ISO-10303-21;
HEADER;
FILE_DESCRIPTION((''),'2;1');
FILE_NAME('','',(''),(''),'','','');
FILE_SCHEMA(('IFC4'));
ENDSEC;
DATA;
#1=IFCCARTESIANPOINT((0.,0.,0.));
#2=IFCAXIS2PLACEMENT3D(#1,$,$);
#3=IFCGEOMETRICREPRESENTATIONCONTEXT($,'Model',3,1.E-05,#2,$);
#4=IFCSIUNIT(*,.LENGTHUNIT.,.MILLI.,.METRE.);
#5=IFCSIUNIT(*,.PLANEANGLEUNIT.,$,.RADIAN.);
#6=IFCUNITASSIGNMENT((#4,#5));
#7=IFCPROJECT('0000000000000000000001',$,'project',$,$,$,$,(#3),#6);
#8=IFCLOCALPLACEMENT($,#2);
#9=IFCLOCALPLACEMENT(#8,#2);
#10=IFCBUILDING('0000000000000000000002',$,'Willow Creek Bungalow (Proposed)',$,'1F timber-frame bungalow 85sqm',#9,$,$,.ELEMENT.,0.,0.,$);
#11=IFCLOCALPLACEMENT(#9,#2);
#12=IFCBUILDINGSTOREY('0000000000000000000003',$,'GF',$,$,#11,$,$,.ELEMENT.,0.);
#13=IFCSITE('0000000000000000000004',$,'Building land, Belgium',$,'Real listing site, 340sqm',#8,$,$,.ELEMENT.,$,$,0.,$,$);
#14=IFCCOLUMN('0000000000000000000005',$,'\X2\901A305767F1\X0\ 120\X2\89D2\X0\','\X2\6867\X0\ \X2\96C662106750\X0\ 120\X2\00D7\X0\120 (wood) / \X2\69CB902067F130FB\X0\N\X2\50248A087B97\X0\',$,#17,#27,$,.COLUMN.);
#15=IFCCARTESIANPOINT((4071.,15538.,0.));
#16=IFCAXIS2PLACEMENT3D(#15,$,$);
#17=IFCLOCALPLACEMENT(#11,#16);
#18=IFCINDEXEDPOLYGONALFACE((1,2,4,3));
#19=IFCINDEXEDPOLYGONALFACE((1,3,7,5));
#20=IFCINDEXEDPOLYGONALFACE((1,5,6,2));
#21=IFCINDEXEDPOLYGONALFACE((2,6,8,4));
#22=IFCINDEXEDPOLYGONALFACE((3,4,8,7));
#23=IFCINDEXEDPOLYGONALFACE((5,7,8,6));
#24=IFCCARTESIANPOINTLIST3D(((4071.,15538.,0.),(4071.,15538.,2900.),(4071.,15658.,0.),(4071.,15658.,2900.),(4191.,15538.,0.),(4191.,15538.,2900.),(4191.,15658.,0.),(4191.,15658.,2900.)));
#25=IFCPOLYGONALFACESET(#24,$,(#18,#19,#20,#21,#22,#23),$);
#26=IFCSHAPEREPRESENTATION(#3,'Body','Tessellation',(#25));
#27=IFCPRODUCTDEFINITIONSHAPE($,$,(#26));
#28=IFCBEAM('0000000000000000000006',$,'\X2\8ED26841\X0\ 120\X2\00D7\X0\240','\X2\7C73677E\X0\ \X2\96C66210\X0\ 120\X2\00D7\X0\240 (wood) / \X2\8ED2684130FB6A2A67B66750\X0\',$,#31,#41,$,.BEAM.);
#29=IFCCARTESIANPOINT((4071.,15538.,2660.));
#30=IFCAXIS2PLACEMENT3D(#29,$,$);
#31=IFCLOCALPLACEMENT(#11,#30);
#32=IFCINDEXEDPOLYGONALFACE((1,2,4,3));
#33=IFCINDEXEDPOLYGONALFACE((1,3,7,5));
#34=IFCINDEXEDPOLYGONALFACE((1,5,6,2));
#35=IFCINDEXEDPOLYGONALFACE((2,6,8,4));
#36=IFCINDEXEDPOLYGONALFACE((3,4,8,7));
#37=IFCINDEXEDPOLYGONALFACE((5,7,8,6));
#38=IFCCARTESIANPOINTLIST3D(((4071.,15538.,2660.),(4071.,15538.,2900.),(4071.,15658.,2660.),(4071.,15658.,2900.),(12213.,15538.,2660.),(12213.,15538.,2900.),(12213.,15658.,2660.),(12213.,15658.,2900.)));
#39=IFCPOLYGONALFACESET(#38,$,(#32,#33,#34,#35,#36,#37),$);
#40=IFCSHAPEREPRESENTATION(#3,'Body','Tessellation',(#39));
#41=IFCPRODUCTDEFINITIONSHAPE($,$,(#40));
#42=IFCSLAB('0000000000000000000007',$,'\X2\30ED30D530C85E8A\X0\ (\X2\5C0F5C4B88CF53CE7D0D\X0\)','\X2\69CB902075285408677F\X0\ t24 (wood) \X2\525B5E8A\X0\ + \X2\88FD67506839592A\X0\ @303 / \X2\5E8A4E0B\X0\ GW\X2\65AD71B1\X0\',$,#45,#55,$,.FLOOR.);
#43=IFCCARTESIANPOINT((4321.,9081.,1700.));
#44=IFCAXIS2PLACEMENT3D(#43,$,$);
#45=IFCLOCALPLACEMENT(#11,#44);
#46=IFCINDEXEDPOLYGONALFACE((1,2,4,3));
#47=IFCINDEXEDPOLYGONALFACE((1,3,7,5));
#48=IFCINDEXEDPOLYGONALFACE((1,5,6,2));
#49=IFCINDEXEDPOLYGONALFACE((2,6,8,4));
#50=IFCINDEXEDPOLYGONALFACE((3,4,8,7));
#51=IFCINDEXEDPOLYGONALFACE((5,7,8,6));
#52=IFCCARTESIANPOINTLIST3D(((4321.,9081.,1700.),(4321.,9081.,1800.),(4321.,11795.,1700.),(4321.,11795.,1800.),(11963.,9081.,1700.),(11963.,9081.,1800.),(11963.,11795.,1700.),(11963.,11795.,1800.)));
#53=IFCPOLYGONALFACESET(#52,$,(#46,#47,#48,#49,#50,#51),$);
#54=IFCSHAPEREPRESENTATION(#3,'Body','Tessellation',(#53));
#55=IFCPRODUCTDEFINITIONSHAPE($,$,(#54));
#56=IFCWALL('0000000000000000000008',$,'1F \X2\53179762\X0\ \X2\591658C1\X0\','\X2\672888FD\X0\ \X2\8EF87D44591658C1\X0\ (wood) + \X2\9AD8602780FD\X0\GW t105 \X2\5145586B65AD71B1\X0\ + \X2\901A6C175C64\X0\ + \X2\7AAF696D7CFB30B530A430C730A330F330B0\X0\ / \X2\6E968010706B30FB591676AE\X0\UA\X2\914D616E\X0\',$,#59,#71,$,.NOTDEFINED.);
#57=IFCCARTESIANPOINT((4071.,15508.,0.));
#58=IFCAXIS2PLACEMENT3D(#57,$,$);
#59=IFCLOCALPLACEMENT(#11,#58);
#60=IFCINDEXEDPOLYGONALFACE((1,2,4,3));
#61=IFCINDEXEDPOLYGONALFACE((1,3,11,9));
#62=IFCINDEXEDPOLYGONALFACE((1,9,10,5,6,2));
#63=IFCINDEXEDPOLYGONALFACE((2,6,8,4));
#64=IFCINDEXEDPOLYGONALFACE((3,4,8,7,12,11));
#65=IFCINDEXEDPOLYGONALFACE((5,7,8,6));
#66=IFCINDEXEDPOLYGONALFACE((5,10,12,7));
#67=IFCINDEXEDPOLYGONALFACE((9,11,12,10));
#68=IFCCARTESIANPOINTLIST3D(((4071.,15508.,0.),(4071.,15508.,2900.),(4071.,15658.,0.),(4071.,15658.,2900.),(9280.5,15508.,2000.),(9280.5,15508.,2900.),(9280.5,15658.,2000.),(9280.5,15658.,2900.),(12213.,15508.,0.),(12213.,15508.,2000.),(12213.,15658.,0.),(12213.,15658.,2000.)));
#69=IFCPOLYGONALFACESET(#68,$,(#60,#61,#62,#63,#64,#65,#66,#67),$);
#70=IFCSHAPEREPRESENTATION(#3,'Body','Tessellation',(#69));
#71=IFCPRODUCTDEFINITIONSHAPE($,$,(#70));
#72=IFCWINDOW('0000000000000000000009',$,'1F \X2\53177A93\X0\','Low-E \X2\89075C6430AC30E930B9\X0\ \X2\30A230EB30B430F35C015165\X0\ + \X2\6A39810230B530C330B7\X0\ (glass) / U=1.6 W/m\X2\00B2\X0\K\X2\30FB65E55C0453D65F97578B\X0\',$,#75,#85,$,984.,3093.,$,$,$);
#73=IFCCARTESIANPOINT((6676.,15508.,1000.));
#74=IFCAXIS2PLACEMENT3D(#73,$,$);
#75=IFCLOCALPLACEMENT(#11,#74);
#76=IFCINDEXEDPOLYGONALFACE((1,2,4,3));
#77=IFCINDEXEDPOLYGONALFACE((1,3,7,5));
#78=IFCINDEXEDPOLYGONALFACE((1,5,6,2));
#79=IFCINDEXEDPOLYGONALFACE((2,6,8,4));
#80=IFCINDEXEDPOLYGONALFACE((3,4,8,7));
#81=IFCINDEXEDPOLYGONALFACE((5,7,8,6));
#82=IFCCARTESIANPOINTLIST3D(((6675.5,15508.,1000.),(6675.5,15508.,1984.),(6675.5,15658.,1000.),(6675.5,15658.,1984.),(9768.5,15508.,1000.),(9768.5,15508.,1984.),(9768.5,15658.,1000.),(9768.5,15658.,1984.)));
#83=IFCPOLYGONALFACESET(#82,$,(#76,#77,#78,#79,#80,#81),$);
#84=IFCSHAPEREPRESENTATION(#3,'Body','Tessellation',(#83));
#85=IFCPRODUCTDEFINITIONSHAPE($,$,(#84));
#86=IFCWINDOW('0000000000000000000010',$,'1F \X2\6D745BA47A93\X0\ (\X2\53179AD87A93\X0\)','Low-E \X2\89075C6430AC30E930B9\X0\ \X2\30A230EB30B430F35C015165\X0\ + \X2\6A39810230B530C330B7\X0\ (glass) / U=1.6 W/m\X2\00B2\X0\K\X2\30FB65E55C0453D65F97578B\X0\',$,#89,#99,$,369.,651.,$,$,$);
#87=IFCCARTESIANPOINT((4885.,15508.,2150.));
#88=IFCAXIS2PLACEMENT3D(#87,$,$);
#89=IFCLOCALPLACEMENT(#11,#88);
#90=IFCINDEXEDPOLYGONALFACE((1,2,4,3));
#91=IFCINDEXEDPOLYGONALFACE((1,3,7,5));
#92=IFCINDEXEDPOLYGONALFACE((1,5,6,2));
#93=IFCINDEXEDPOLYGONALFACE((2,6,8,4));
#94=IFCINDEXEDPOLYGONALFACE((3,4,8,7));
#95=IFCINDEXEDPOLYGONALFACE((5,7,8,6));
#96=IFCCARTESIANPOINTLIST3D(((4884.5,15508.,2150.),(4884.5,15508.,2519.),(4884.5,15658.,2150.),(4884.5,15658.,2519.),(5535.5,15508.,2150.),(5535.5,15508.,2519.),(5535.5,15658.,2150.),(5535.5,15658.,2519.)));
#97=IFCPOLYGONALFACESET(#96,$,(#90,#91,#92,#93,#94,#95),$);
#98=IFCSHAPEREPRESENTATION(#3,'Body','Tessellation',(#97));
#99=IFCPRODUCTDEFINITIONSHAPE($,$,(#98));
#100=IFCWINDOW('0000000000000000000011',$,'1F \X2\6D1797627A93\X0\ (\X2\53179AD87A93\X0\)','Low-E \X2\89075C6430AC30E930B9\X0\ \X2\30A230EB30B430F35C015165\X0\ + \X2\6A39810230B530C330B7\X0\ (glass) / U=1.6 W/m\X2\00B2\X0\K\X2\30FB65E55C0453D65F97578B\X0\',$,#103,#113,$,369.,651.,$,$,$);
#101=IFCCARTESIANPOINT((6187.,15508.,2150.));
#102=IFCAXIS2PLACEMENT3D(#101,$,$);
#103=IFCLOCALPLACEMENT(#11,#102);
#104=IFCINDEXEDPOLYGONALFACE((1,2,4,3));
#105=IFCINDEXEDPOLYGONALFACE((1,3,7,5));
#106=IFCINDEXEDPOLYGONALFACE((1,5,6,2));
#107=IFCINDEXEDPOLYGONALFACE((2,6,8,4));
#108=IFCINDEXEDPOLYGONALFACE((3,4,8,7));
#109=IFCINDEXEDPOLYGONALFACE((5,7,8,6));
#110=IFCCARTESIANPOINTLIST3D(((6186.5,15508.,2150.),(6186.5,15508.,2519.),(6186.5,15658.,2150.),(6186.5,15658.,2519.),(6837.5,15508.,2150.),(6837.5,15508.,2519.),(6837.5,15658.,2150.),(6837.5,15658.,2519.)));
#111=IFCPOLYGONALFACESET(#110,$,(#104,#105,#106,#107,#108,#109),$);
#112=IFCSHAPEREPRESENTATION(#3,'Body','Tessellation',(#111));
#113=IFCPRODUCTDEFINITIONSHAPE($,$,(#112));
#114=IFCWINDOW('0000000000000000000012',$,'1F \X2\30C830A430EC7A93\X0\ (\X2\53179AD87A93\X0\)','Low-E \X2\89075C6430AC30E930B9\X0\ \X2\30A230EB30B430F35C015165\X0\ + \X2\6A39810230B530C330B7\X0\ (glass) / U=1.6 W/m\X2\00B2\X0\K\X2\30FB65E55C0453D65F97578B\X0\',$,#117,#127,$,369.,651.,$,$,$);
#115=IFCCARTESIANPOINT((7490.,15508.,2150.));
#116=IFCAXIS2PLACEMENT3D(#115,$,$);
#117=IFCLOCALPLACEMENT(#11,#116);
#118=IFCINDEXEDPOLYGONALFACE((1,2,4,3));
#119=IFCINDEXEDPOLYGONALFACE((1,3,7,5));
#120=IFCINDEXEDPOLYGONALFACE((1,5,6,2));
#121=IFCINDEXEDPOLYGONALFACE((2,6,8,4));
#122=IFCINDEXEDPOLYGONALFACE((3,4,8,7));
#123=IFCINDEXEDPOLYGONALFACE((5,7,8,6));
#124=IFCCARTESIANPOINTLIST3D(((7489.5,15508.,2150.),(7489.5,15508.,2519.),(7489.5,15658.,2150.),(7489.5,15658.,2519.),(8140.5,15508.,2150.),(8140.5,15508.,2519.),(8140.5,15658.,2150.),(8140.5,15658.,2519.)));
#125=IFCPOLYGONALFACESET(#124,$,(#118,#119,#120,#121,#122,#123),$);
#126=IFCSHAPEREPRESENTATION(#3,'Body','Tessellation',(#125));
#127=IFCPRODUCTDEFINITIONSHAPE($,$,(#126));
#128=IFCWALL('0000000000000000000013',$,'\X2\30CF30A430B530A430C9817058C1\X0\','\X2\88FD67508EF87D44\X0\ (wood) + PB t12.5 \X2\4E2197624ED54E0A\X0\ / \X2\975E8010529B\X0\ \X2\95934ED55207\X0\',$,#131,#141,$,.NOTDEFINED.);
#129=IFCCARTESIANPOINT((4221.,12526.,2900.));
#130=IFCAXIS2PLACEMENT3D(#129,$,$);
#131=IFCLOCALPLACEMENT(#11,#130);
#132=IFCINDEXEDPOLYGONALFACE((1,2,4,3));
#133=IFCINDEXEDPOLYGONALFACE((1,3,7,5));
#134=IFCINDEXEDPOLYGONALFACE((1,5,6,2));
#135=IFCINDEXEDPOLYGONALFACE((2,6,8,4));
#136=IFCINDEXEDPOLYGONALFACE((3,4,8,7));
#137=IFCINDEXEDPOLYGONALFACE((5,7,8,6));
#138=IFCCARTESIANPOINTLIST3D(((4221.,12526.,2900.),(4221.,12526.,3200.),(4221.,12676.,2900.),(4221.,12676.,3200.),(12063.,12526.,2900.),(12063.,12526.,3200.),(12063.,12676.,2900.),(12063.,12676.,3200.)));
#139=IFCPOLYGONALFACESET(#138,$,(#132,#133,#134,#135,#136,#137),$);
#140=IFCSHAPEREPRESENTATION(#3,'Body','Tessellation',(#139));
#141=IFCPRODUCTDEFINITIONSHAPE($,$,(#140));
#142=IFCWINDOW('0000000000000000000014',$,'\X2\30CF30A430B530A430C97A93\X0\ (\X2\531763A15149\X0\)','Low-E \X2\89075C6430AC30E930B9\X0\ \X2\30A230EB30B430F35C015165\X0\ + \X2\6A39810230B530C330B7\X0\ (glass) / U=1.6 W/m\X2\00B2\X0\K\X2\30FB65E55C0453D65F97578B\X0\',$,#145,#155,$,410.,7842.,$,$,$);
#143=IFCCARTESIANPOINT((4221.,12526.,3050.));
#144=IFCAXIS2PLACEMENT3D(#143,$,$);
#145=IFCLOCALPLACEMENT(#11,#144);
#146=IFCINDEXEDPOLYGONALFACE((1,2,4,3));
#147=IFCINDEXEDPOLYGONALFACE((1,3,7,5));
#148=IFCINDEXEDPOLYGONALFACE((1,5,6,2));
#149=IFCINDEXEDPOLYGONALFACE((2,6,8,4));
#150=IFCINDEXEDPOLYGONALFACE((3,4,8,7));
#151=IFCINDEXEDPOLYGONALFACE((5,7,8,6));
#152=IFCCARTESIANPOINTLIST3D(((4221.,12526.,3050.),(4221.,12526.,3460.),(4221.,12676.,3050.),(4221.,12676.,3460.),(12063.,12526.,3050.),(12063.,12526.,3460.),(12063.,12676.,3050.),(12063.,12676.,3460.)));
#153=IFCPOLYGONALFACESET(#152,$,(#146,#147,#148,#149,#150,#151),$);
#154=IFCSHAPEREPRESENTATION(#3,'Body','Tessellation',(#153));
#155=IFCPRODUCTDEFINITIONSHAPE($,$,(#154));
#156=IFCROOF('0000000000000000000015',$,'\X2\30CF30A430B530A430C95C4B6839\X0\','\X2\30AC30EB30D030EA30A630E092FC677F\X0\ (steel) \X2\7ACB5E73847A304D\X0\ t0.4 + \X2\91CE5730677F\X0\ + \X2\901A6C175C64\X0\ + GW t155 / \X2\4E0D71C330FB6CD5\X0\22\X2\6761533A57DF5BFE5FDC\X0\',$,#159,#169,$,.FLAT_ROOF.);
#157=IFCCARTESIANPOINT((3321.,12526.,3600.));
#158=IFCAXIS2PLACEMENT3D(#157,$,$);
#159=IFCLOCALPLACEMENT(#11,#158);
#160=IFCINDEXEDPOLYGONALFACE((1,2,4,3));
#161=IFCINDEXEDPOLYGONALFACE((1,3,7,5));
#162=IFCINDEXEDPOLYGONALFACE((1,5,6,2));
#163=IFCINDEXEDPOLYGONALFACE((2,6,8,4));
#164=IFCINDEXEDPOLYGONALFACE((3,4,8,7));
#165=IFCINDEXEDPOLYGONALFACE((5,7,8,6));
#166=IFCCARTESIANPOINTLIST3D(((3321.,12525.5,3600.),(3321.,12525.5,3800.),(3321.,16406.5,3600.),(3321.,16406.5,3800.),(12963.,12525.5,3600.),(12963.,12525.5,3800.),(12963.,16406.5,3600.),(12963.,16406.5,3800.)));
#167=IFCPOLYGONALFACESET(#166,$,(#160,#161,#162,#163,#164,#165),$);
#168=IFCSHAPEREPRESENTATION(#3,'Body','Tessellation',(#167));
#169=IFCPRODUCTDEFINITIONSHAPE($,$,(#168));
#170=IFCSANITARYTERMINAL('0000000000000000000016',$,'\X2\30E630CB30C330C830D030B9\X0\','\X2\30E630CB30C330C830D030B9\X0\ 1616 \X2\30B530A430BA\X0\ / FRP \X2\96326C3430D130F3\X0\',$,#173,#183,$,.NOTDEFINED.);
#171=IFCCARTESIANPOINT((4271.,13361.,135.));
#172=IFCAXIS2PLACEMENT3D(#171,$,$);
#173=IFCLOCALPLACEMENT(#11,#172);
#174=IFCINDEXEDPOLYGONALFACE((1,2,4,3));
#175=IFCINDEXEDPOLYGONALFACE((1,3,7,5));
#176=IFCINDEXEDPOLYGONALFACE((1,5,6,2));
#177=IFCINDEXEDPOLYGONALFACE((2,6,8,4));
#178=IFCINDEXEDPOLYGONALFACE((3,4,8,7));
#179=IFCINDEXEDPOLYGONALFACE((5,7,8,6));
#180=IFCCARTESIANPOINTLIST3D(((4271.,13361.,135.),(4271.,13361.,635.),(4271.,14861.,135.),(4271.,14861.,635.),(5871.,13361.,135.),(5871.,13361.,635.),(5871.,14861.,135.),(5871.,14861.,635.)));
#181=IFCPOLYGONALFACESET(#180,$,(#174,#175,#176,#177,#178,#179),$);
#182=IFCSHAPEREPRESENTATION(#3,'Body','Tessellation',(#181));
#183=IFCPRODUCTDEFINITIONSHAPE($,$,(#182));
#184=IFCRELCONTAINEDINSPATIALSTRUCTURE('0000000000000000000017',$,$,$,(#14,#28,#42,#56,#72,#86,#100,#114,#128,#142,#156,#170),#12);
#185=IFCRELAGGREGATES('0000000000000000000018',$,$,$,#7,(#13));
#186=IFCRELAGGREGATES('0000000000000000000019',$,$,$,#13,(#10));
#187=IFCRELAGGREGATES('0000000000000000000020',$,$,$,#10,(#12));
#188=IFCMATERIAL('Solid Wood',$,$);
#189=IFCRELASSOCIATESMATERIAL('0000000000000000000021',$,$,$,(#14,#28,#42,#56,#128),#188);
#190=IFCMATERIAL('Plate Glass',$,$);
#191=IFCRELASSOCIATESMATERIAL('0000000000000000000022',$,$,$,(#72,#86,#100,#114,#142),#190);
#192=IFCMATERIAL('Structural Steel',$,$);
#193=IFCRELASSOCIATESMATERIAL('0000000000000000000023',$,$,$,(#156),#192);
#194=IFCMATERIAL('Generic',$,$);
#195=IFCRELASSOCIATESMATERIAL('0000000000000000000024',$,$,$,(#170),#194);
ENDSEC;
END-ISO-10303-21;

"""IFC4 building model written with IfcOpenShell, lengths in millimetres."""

from ifc_helpers import new_model, si_unit, frame, frame_2d, origin, place, context, project, spatial, rectangle, extrude, material, element, fill, save


model = new_model("IFC4")

# Units and contexts
model_context = context("Model", 3, precision=1e-05, world=origin())
ifc_project = project(units=[si_unit("LENGTHUNIT", "METRE", prefix="MILLI"), si_unit("PLANEANGLEUNIT", "RADIAN")], contexts=[model_context])

# Site, building, storey
site_placement = place(None, origin())
site = spatial("IfcSite", under=ifc_project, at=site_placement, Name="Building land, Belgium", ObjectType="Real listing site, 340sqm", CompositionType="ELEMENT", RefElevation=0.0)
building_placement = place(site_placement, origin())
building = spatial("IfcBuilding", under=site, at=building_placement, Name="Willow Creek Bungalow (Proposed)", ObjectType="1F timber-frame bungalow 85sqm", CompositionType="ELEMENT", ElevationOfRefHeight=0.0, ElevationOfTerrain=0.0)
storey_placement = place(building_placement, origin())
storey = spatial("IfcBuildingStorey", under=building, at=storey_placement, Name="GF", CompositionType="ELEMENT", Elevation=0.0)

# Column
ifc_material_1 = material(Name="Solid Wood")
column_1_placement = place(storey_placement, frame((4071.0, 15538.0, 0.0)))
element("IfcColumn", 1, at=column_1_placement, inside=storey, material=ifc_material_1, Name="通し柱 120角", Description="桧 集成材 120×120 (wood) / 構造柱・N値計算", PredefinedType="COLUMN", context=model_context, shape_type="SweptSolid", body=[
    extrude(rectangle(XDim=120.0, YDim=120.0, at=frame_2d((60.0, 60.0))), frame((4071.0, 15538.0, 0.0)), (0.0, 0.0, 1.0), 2900.0),
])

# Beam
beam_1_placement = place(storey_placement, frame((4071.0, 15538.0, 2660.0)))
element("IfcBeam", 2, at=beam_1_placement, inside=storey, material=ifc_material_1, Name="軒桁 120×240", Description="米松 集成 120×240 (wood) / 軒桁・横架材", PredefinedType="BEAM", context=model_context, shape_type="SweptSolid", body=[
    extrude(rectangle(XDim=8142.0, YDim=120.0, at=frame_2d((4071.0, 60.0))), frame((4071.0, 15538.0, 2660.0)), (0.0, 0.0, 1.0), 240.0),
])

# Slab
slab_placement = place(storey_placement, frame((4321.0, 9081.0, 1700.0)))
element("IfcSlab", 3, at=slab_placement, inside=storey, material=ifc_material_1, Name="ロフト床 (小屋裏収納)", Description="構造用合板 t24 (wood) 剛床 + 製材根太 @303 / 床下 GW断熱", PredefinedType="FLOOR", context=model_context, shape_type="SweptSolid", body=[
    extrude(rectangle(XDim=7642.0, YDim=2714.0, at=frame_2d((3821.0, 1357.0))), frame((4321.0, 9081.0, 1700.0)), (0.0, 0.0, 1.0), 100.0),
])

# Wall, openings, windows
wall_1_placement = place(storey_placement, frame((4071.0, 15508.0, 0.0)))
wall_1 = element("IfcWall", 4, at=wall_1_placement, inside=storey, material=ifc_material_1, Name="1F 北面 外壁", Description="木製 軸組外壁 (wood) + 高性能GW t105 充填断熱 + 通気層 + 窯業系サイディング / 準耐火・外皮UA配慮", PredefinedType="NOTDEFINED", context=model_context, shape_type="SweptSolid", body=[
    extrude(rectangle(XDim=8142.0, YDim=150.0, at=frame_2d((4071.0, 75.0))), frame((4071.0, 15508.0, 0.0)), (0.0, 0.0, 1.0), 2900.0),
])
opening_1_placement = place(storey_placement, frame((6676.0, 15508.0, 1000.0)))
opening_1 = element("IfcOpeningElement", 5, at=opening_1_placement, cuts=wall_1, PredefinedType="NOTDEFINED", context=model_context, shape_type="SweptSolid", body=[
    extrude(rectangle(XDim=3093.0, YDim=150.0, at=frame_2d((1546.0, 75.0))), frame((6676.0, 15508.0, 1000.0)), (0.0, 0.0, 1.0), 984.0),
])
opening_2_placement = place(storey_placement, frame((4885.0, 15508.0, 2150.0)))
opening_2 = element("IfcOpeningElement", 6, at=opening_2_placement, cuts=wall_1, PredefinedType="NOTDEFINED", context=model_context, shape_type="SweptSolid", body=[
    extrude(rectangle(XDim=651.0, YDim=150.0, at=frame_2d((325.0, 75.0))), frame((4885.0, 15508.0, 2150.0)), (0.0, 0.0, 1.0), 369.0),
])
opening_3_placement = place(storey_placement, frame((6187.0, 15508.0, 2150.0)))
opening_3 = element("IfcOpeningElement", 7, at=opening_3_placement, cuts=wall_1, PredefinedType="NOTDEFINED", context=model_context, shape_type="SweptSolid", body=[
    extrude(rectangle(XDim=651.0, YDim=150.0, at=frame_2d((325.0, 75.0))), frame((6187.0, 15508.0, 2150.0)), (0.0, 0.0, 1.0), 369.0),
])
opening_4_placement = place(storey_placement, frame((7490.0, 15508.0, 2150.0)))
opening_4 = element("IfcOpeningElement", 8, at=opening_4_placement, cuts=wall_1, PredefinedType="NOTDEFINED", context=model_context, shape_type="SweptSolid", body=[
    extrude(rectangle(XDim=651.0, YDim=150.0, at=frame_2d((325.0, 75.0))), frame((7490.0, 15508.0, 2150.0)), (0.0, 0.0, 1.0), 369.0),
])
ifc_material_2 = material(Name="Plate Glass")
window_1_placement = place(storey_placement, frame((6676.0, 15508.0, 1000.0)))
window_1 = element("IfcWindow", 9, at=window_1_placement, inside=storey, material=ifc_material_2, Name="1F 北窓", Description="Low-E 複層ガラス アルゴン封入 + 樹脂サッシ (glass) / U=1.6 W/m²K・日射取得型", OverallHeight=984.0, OverallWidth=3093.0, context=model_context, shape_type="SweptSolid", body=[
    extrude(rectangle(XDim=3093.0, YDim=150.0, at=frame_2d((1546.0, 75.0))), frame((6676.0, 15508.0, 1000.0)), (0.0, 0.0, 1.0), 984.0),
])
fill(opening_1, window_1)
window_2_placement = place(storey_placement, frame((4885.0, 15508.0, 2150.0)))
window_2 = element("IfcWindow", 10, at=window_2_placement, inside=storey, material=ifc_material_2, Name="1F 浴室窓 (北高窓)", Description="Low-E 複層ガラス アルゴン封入 + 樹脂サッシ (glass) / U=1.6 W/m²K・日射取得型", OverallHeight=369.0, OverallWidth=651.0, context=model_context, shape_type="SweptSolid", body=[
    extrude(rectangle(XDim=651.0, YDim=150.0, at=frame_2d((325.0, 75.0))), frame((4885.0, 15508.0, 2150.0)), (0.0, 0.0, 1.0), 369.0),
])
fill(opening_2, window_2)
window_3_placement = place(storey_placement, frame((6187.0, 15508.0, 2150.0)))
window_3 = element("IfcWindow", 11, at=window_3_placement, inside=storey, material=ifc_material_2, Name="1F 洗面窓 (北高窓)", Description="Low-E 複層ガラス アルゴン封入 + 樹脂サッシ (glass) / U=1.6 W/m²K・日射取得型", OverallHeight=369.0, OverallWidth=651.0, context=model_context, shape_type="SweptSolid", body=[
    extrude(rectangle(XDim=651.0, YDim=150.0, at=frame_2d((325.0, 75.0))), frame((6187.0, 15508.0, 2150.0)), (0.0, 0.0, 1.0), 369.0),
])
fill(opening_3, window_3)
window_4_placement = place(storey_placement, frame((7490.0, 15508.0, 2150.0)))
window_4 = element("IfcWindow", 12, at=window_4_placement, inside=storey, material=ifc_material_2, Name="1F トイレ窓 (北高窓)", Description="Low-E 複層ガラス アルゴン封入 + 樹脂サッシ (glass) / U=1.6 W/m²K・日射取得型", OverallHeight=369.0, OverallWidth=651.0, context=model_context, shape_type="SweptSolid", body=[
    extrude(rectangle(XDim=651.0, YDim=150.0, at=frame_2d((325.0, 75.0))), frame((7490.0, 15508.0, 2150.0)), (0.0, 0.0, 1.0), 369.0),
])
fill(opening_4, window_4)

# Wall, opening, window
wall_2_placement = place(storey_placement, frame((4221.0, 12526.0, 2900.0)))
wall_2 = element("IfcWall", 13, at=wall_2_placement, inside=storey, material=ifc_material_1, Name="ハイサイド腰壁", Description="製材軸組 (wood) + PB t12.5 両面仕上 / 非耐力 間仕切", PredefinedType="NOTDEFINED", context=model_context, shape_type="SweptSolid", body=[
    extrude(rectangle(XDim=7842.0, YDim=150.0, at=frame_2d((3921.0, 75.0))), frame((4221.0, 12526.0, 2900.0)), (0.0, 0.0, 1.0), 700.0),
])
opening_5_placement = place(storey_placement, frame((4221.0, 12526.0, 3050.0)))
opening_5 = element("IfcOpeningElement", 14, at=opening_5_placement, cuts=wall_2, PredefinedType="NOTDEFINED", context=model_context, shape_type="SweptSolid", body=[
    extrude(rectangle(XDim=7842.0, YDim=150.0, at=frame_2d((3921.0, 75.0))), frame((4221.0, 12526.0, 3050.0)), (0.0, 0.0, 1.0), 410.0),
])
window_5_placement = place(storey_placement, frame((4221.0, 12526.0, 3050.0)))
window_5 = element("IfcWindow", 15, at=window_5_placement, inside=storey, material=ifc_material_2, Name="ハイサイド窓 (北採光)", Description="Low-E 複層ガラス アルゴン封入 + 樹脂サッシ (glass) / U=1.6 W/m²K・日射取得型", OverallHeight=410.0, OverallWidth=7842.0, context=model_context, shape_type="SweptSolid", body=[
    extrude(rectangle(XDim=7842.0, YDim=150.0, at=frame_2d((3921.0, 75.0))), frame((4221.0, 12526.0, 3050.0)), (0.0, 0.0, 1.0), 410.0),
])
fill(opening_5, window_5)

# Roof
ifc_material_3 = material(Name="Structural Steel")
roof_placement = place(storey_placement, frame((3321.0, 12526.0, 3600.0)))
element("IfcRoof", 16, at=roof_placement, inside=storey, material=ifc_material_3, Name="ハイサイド屋根", Description="ガルバリウム鋼板 (steel) 立平葺き t0.4 + 野地板 + 通気層 + GW t155 / 不燃・法22条区域対応", PredefinedType="FLAT_ROOF", context=model_context, shape_type="SweptSolid", body=[
    extrude(rectangle(XDim=9642.0, YDim=3881.0, at=frame_2d((4821.0, 1940.0))), frame((3321.0, 12526.0, 3600.0)), (0.0, 0.0, 1.0), 200.0),
])

# Sanitary terminal
ifc_material_4 = material(Name="Generic")
sanitary_terminal_placement = place(storey_placement, frame((4271.0, 13361.0, 135.0)))
element("IfcSanitaryTerminal", 17, at=sanitary_terminal_placement, inside=storey, material=ifc_material_4, Name="ユニットバス", Description="ユニットバス 1616 サイズ / FRP 防水パン", PredefinedType="NOTDEFINED", context=model_context, shape_type="SweptSolid", body=[
    extrude(rectangle(XDim=1600.0, YDim=1500.0, at=frame_2d((800.0, 750.0))), frame((4271.0, 13361.0, 135.0)), (0.0, 0.0, 1.0), 500.0),
])

save(model, "model.ifc")
